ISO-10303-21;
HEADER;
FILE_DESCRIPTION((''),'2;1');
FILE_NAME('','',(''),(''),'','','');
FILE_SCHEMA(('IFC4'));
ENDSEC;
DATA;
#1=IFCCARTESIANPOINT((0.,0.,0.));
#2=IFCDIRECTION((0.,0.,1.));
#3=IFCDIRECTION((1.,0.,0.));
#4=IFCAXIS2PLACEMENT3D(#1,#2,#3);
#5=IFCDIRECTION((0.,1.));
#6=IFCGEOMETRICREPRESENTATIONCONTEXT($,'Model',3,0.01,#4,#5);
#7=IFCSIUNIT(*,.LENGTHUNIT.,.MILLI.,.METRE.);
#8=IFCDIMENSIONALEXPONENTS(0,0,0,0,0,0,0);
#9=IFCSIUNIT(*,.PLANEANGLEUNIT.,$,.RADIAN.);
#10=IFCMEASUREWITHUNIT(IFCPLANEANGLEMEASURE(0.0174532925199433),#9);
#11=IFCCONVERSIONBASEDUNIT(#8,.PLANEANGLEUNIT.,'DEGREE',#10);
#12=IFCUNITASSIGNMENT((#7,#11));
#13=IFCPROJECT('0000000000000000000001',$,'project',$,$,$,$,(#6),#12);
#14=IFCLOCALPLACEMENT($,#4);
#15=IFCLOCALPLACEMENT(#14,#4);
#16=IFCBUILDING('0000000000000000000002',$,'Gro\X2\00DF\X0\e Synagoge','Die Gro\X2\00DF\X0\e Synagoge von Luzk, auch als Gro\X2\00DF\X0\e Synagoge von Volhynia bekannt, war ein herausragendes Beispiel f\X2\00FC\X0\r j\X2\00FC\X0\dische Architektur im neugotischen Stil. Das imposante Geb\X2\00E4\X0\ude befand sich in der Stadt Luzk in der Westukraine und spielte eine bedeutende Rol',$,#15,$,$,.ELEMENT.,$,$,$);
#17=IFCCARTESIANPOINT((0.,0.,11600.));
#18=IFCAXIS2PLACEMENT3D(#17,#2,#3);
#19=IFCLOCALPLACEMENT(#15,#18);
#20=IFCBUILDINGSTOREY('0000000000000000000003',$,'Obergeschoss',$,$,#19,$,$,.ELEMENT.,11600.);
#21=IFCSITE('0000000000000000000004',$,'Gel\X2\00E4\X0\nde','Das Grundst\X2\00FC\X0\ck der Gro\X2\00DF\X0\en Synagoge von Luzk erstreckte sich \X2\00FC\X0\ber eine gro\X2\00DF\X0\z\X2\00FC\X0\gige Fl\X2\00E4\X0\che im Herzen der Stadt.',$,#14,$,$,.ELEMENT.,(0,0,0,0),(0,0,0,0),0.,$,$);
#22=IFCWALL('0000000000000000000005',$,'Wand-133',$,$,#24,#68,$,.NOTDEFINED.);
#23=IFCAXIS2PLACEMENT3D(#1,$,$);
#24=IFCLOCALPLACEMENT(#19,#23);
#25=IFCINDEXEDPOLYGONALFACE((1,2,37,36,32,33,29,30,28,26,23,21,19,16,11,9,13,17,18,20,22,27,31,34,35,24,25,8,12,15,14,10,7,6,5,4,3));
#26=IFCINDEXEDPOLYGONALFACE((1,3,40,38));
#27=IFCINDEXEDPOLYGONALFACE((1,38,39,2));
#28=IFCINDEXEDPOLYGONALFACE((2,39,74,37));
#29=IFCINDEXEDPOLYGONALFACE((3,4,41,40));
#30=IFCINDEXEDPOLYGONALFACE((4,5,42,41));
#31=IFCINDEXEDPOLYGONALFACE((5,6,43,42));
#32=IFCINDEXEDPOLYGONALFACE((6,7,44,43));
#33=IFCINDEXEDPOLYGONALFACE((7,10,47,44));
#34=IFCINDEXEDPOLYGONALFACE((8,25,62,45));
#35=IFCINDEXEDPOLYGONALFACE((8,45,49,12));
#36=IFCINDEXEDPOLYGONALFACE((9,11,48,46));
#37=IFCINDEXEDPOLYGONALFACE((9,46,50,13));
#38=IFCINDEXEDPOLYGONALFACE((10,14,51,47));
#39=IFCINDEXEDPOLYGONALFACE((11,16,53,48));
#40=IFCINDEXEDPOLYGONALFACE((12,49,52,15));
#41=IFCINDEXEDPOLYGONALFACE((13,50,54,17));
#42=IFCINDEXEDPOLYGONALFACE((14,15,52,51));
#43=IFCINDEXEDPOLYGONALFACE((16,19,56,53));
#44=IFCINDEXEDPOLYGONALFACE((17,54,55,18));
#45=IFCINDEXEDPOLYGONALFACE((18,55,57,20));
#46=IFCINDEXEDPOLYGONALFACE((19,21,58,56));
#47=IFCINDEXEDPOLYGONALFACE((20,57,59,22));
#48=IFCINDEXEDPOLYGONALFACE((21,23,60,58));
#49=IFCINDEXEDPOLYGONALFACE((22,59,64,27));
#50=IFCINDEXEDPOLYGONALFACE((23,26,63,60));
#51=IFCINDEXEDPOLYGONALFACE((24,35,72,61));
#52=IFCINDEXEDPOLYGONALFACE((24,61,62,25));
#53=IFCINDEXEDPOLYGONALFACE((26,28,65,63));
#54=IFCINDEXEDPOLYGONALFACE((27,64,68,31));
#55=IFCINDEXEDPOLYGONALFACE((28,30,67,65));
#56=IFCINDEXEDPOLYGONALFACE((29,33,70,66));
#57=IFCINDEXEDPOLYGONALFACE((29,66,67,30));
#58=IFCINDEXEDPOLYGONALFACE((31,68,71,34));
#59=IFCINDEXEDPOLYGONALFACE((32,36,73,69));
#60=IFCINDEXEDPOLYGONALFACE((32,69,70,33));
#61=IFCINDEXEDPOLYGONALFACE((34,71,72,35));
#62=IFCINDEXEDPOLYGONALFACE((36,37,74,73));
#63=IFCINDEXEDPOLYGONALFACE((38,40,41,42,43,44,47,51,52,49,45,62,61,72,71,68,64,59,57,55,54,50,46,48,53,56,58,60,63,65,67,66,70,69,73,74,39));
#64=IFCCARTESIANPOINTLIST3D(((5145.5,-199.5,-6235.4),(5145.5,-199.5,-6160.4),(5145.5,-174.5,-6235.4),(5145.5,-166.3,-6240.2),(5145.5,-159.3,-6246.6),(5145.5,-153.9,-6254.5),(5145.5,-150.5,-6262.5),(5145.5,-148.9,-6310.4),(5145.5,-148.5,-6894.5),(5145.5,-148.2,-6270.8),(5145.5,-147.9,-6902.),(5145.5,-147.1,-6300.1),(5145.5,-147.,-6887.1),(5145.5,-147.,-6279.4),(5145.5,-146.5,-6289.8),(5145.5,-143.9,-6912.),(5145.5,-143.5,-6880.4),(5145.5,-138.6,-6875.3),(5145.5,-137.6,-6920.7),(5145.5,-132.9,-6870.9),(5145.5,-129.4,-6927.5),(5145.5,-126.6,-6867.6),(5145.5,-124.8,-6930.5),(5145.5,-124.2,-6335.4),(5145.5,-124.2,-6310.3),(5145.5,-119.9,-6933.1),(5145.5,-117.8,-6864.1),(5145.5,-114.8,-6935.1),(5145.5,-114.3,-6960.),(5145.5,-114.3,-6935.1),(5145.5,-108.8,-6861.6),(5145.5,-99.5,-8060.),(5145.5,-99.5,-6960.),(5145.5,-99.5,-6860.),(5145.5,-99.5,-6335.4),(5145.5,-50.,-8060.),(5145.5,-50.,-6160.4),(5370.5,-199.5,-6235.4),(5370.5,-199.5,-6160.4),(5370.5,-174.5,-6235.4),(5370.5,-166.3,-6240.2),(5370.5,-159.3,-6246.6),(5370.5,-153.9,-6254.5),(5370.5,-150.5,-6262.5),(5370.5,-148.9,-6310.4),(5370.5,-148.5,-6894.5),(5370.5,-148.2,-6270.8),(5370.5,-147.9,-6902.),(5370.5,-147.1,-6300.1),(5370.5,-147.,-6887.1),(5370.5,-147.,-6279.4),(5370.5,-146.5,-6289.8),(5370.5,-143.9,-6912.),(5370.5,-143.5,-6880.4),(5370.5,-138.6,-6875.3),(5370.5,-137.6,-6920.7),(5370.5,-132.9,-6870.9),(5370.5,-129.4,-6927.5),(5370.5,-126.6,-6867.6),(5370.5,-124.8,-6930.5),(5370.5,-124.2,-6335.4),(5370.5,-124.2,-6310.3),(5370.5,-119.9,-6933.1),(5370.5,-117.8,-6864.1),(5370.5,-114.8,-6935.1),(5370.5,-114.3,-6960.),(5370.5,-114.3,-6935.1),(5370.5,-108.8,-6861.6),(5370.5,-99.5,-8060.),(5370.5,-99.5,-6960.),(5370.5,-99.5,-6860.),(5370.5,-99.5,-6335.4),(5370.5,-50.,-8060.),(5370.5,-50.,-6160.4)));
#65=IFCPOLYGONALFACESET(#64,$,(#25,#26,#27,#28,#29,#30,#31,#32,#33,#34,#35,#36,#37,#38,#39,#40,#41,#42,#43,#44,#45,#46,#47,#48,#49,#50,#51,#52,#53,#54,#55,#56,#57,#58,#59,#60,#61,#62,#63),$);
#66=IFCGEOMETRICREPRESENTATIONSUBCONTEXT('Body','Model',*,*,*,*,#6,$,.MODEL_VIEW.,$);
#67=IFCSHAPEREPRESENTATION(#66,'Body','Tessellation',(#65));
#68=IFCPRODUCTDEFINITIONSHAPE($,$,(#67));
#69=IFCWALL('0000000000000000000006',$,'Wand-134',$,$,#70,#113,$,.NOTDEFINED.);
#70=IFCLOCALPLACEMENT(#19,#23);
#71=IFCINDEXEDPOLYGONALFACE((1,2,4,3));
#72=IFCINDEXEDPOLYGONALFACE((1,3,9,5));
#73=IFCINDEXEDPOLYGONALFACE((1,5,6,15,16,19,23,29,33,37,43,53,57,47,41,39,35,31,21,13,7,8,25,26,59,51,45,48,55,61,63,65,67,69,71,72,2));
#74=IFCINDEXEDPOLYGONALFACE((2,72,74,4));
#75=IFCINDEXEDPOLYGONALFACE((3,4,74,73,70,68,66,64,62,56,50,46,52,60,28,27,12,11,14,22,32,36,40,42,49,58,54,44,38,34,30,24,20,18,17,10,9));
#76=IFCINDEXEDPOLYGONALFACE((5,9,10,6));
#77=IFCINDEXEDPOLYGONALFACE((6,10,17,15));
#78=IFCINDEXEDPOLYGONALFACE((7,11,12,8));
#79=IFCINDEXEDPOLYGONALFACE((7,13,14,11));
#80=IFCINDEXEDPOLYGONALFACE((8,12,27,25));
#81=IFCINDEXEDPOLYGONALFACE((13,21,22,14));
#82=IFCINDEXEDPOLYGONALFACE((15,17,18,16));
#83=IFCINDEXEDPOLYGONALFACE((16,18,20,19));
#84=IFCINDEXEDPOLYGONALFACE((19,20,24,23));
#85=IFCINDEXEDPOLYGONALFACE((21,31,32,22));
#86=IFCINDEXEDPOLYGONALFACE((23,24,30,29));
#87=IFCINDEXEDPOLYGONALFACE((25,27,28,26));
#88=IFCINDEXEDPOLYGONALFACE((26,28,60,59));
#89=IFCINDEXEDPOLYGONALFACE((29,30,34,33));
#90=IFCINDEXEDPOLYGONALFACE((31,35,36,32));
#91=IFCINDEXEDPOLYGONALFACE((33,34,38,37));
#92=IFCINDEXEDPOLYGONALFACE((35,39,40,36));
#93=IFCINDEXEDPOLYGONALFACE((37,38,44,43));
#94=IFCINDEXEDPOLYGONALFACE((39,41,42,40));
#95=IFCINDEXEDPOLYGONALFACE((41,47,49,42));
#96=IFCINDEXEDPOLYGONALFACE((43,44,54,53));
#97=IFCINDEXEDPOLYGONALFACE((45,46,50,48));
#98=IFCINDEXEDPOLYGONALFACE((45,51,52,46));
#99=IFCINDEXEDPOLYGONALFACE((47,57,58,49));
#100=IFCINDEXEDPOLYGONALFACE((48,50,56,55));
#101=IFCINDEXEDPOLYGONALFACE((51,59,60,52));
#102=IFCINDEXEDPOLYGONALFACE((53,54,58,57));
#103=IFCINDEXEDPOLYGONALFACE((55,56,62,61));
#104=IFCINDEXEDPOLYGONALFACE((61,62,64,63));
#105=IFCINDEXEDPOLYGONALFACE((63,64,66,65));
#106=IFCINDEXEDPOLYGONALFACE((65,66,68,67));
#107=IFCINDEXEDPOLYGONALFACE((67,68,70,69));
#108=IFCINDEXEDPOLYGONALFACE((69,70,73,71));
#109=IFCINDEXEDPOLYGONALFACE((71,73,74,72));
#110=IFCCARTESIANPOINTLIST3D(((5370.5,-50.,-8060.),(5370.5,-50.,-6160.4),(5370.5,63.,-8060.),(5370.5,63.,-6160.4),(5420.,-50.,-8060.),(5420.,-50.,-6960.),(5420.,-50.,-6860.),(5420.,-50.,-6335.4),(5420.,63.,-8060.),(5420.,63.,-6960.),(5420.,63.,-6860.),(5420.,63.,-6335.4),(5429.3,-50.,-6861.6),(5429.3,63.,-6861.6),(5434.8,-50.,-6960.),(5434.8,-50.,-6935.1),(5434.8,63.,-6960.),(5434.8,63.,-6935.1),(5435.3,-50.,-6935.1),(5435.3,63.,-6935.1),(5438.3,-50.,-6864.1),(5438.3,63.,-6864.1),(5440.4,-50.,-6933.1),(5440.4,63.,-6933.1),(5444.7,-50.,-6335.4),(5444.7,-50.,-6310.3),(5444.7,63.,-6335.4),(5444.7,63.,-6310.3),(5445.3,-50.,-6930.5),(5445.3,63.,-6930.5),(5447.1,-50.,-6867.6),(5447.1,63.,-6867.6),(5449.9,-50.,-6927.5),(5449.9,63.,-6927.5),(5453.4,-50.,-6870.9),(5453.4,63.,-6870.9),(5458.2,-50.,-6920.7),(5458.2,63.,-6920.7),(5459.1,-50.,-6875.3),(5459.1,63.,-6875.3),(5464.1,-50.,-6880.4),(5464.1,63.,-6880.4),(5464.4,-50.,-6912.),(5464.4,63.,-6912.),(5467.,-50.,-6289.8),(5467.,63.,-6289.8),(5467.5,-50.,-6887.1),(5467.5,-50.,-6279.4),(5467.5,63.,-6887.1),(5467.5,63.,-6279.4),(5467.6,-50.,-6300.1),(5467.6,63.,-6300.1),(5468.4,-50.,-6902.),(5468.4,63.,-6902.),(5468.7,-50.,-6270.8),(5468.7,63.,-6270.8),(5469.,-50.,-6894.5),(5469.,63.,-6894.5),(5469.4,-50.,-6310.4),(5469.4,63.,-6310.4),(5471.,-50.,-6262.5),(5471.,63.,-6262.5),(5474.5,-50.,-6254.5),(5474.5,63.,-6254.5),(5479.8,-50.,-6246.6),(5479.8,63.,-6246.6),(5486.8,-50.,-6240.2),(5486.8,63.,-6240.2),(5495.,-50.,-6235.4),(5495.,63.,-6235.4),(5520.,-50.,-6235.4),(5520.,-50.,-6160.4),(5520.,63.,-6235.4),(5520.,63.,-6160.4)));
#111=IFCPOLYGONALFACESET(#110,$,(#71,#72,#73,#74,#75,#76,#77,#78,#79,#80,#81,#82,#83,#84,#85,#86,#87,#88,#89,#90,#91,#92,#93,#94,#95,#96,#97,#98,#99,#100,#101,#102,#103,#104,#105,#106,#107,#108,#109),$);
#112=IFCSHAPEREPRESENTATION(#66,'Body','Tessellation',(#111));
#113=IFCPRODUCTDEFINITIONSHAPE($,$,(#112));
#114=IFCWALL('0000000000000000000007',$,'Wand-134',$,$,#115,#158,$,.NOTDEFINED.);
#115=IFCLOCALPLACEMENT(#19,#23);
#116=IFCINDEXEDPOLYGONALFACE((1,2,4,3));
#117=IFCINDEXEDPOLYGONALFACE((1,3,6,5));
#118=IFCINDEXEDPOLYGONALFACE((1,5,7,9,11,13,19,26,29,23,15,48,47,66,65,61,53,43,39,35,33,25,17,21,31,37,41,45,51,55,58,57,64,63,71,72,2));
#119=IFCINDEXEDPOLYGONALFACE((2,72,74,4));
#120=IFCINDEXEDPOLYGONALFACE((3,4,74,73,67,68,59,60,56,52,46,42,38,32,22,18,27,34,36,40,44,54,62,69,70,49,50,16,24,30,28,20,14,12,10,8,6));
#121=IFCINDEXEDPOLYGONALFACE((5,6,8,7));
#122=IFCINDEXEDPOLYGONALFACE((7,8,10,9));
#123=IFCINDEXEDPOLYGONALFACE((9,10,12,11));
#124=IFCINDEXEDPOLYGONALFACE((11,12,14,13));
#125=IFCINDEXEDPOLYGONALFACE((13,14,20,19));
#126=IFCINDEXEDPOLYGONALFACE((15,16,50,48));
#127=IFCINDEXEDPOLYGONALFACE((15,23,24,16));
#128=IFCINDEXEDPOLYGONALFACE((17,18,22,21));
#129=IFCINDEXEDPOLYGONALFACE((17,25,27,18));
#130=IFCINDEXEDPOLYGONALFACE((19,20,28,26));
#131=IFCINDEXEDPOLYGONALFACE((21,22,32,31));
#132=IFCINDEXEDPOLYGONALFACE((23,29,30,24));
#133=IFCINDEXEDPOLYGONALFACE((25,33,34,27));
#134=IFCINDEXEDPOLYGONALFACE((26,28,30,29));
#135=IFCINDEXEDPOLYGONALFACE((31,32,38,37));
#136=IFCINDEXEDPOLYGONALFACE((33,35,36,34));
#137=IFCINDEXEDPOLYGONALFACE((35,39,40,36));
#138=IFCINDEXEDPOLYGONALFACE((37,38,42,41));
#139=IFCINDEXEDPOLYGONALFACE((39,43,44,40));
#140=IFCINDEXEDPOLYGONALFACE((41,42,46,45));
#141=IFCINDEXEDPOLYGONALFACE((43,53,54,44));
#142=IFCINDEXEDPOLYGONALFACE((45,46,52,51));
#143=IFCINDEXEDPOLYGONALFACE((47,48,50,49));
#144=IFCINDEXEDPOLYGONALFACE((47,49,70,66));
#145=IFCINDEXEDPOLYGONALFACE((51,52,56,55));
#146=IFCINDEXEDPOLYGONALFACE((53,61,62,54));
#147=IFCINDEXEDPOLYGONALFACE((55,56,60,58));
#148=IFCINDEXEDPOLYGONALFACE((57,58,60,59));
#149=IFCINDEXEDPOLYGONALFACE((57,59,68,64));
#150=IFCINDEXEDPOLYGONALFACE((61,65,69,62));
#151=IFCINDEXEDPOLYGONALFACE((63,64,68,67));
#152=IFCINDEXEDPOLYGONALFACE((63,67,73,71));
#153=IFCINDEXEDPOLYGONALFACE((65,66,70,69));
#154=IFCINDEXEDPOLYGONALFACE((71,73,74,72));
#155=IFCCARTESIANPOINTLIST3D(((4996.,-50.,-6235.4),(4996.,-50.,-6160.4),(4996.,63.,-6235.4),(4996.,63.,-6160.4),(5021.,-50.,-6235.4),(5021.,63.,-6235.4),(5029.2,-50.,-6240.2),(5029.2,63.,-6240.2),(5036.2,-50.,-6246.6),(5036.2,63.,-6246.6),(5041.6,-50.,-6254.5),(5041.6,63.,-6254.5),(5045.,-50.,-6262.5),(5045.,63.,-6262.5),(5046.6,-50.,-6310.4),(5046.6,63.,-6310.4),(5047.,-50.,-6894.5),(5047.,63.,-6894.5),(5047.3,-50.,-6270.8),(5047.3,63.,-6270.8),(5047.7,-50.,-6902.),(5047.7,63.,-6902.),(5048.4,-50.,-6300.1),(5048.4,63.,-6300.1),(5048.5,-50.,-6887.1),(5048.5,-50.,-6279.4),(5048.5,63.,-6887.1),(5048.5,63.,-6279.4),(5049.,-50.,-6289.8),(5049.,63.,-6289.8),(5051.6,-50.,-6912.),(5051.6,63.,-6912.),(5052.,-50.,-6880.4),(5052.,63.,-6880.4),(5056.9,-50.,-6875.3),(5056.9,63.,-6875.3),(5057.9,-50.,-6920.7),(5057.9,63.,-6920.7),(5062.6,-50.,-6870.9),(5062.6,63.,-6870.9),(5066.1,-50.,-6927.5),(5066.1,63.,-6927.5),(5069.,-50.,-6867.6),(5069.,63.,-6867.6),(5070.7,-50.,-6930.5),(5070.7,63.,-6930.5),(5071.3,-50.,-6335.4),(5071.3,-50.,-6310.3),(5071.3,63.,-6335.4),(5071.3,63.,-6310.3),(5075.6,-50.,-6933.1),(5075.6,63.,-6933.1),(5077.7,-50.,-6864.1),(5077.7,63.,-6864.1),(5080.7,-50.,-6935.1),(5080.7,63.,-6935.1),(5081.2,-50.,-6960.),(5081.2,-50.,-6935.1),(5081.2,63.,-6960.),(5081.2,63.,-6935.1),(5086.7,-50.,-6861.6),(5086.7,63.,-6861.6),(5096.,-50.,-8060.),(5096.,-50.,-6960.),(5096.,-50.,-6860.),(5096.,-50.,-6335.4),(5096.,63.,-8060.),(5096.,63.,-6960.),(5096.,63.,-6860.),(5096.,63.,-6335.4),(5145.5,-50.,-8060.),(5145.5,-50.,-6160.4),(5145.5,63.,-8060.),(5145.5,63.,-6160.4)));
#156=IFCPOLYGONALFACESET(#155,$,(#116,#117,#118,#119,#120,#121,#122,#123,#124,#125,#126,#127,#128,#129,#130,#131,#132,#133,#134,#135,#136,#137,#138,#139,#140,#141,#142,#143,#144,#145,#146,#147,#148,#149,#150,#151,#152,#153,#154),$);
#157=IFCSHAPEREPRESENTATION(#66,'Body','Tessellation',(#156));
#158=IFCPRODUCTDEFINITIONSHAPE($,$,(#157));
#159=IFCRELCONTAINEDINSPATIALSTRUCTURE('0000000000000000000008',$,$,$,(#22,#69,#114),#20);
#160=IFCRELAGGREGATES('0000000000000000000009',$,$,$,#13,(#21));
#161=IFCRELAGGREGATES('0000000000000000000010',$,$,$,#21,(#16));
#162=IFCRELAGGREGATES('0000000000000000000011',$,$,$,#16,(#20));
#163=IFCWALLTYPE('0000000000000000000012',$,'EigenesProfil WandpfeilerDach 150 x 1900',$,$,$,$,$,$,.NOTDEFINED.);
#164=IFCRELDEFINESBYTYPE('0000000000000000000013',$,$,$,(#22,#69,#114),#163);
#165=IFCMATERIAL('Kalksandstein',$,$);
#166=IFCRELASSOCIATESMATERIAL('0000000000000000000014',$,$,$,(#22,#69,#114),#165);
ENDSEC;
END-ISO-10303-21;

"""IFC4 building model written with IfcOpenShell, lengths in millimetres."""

from ifc_helpers import new_model, entity, si_unit, converted_unit, direction, frame, origin_with_axes, place, context, subcontext, project, spatial, line, arc, indexed_curve, outline, extrude, material, material_profile, profile_set, type_object, element, save


model = new_model("IFC4")

# Units and contexts
model_context = context("Model", 3, precision=0.01, world=origin_with_axes(), true_north=direction((0.0, 1.0)))
body_context = subcontext(model_context, "Body", "Model", "MODEL_VIEW")
ifc_project = project(units=[si_unit("LENGTHUNIT", "METRE", prefix="MILLI"), converted_unit("PLANEANGLEUNIT", "DEGREE", entity("IfcPlaneAngleMeasure", 0.0174532925199433), si_unit("PLANEANGLEUNIT", "RADIAN"), dimensions=[0, 0, 0, 0, 0, 0, 0])], contexts=[model_context])

# Site, building, storey
site_placement = place(None, origin_with_axes())
site = spatial("IfcSite", under=ifc_project, at=site_placement, Name="Gelände", Description="Das Grundstück der Großen Synagoge von Luzk erstreckte sich über eine großzügige Fläche im Herzen der Stadt.", CompositionType="ELEMENT", RefLatitude=(0, 0, 0, 0), RefLongitude=(0, 0, 0, 0), RefElevation=0.0)
building_placement = place(site_placement, origin_with_axes())
building = spatial("IfcBuilding", under=site, at=building_placement, Name="Große Synagoge", Description="Die Große Synagoge von Luzk, auch als Große Synagoge von Volhynia bekannt, war ein herausragendes Beispiel für jüdische Architektur im neugotischen Stil. Das imposante Gebäude befand sich in der Stadt Luzk in der Westukraine und spielte eine bedeutende Rol", CompositionType="ELEMENT")
storey_placement = place(building_placement, frame((0.0, 0.0, 11600.0), z_axis=(0.0, 0.0, 1.0), x_axis=(1.0, 0.0, 0.0)))
storey = spatial("IfcBuildingStorey", under=building, at=storey_placement, Name="Obergeschoss", CompositionType="ELEMENT", Elevation=11600.0)

# Walls
ifc_material_1 = material(Name="Kalksandstein")
ifc_material_profile = material_profile(ifc_material_1, outline(indexed_curve([(74.2, 1749.6), (98.9, 1749.6), (96.7, 1765.0), (97.0, 1780.5), (99.2, 1793.4), (103.9, 1805.5), (112.6, 1816.7), (124.5, 1824.6), (149.5, 1824.6), (149.5, 1899.6), (0.0, 1899.6), (0.0, 0.0), (49.5, 0.0), (49.5, 1100.0), (64.3, 1100.0), (64.3, 1124.9), (64.8, 1124.9), (72.4, 1128.1), (79.4, 1132.4), (91.1, 1143.4), (97.9, 1157.9), (98.0, 1169.2), (93.5, 1179.5), (85.8, 1187.0), (76.6, 1192.3), (63.3, 1197.2), (49.5, 1200.0), (49.5, 1724.6), (74.2, 1724.6)], segments=[line(1, 2), arc(2, 3, 4), arc(4, 5, 6), arc(6, 7, 8), line(8, 9, 10, 11, 12, 13, 14, 15, 16, 17), arc(17, 18, 19), arc(19, 20, 21), arc(21, 22, 23), arc(23, 24, 25), arc(25, 26, 27), line(27, 28, 29, 1)])), Name="Kalksandstein")
ifc_profile_set = profile_set([ifc_material_profile], Name="EigenesProfil WandpfeilerDach")
wall_type_1 = type_object("IfcWallType", Name="EigenesProfil WandpfeilerDach 150 x 1900", PredefinedType="NOTDEFINED")
wall_1_placement = place(storey_placement, frame((5145.5, -50.0, -8060.0), z_axis=(0.0, 0.0, 1.0), x_axis=(1.0, 0.0, 0.0)))
element("IfcWall", 1, at=wall_1_placement, inside=storey, type_object=wall_type_1, material=ifc_profile_set, Name="Wand-133", PredefinedType="NOTDEFINED", context=body_context, shape_type="SweptSolid", body=[
    extrude(outline(indexed_curve([(74.2, 1749.6), (98.9, 1749.6), (96.7, 1765.0), (97.0, 1780.5), (99.2, 1793.4), (103.9, 1805.5), (112.6, 1816.7), (124.5, 1824.6), (149.5, 1824.6), (149.5, 1899.6), (0.0, 1899.6), (0.0, 0.0), (49.5, 0.0), (49.5, 1100.0), (64.3, 1100.0), (64.3, 1124.9), (64.8, 1124.9), (72.4, 1128.1), (79.4, 1132.4), (91.1, 1143.4), (97.9, 1157.9), (98.0, 1169.2), (93.5, 1179.5), (85.8, 1187.0), (76.6, 1192.3), (63.3, 1197.2), (49.5, 1200.0), (49.5, 1724.6), (74.2, 1724.6)], segments=[line(1, 2), arc(2, 3, 4), arc(4, 5, 6), arc(6, 7, 8), line(8, 9, 10, 11, 12, 13, 14, 15, 16, 17), arc(17, 18, 19), arc(19, 20, 21), arc(21, 22, 23), arc(23, 24, 25), arc(25, 26, 27), line(27, 28, 29, 1)])), frame((0.0, 0.0, 0.0), z_axis=(-1.0, 0.0, 0.0), x_axis=(0.0, -1.0, 0.0)), (0.0, 0.0, -1.0), 225.0),
])
wall_2_placement = place(storey_placement, frame((5370.5, -50.0, -8060.0), z_axis=(0.0, 0.0, 1.0), x_axis=(0.0, 1.0, 0.0)))
element("IfcWall", 2, at=wall_2_placement, inside=storey, type_object=wall_type_1, material=ifc_profile_set, Name="Wand-134", PredefinedType="NOTDEFINED", context=body_context, shape_type="SweptSolid", body=[
    extrude(outline(indexed_curve([(74.2, 1749.6), (98.9, 1749.6), (96.7, 1765.0), (97.0, 1780.5), (99.2, 1793.4), (103.9, 1805.5), (112.6, 1816.7), (124.5, 1824.6), (149.5, 1824.6), (149.5, 1899.6), (0.0, 1899.6), (0.0, 0.0), (49.5, 0.0), (49.5, 1100.0), (64.3, 1100.0), (64.3, 1124.9), (64.8, 1124.9), (72.4, 1128.1), (79.4, 1132.4), (91.1, 1143.4), (97.9, 1157.9), (98.0, 1169.2), (93.5, 1179.5), (85.8, 1187.0), (76.6, 1192.3), (63.3, 1197.2), (49.5, 1200.0), (49.5, 1724.6), (74.2, 1724.6)], segments=[line(1, 2), arc(2, 3, 4), arc(4, 5, 6), arc(6, 7, 8), line(8, 9, 10, 11, 12, 13, 14, 15, 16, 17), arc(17, 18, 19), arc(19, 20, 21), arc(21, 22, 23), arc(23, 24, 25), arc(25, 26, 27), line(27, 28, 29, 1)])), frame((0.0, 0.0, 0.0), z_axis=(-1.0, 0.0, 0.0), x_axis=(0.0, -1.0, 0.0)), (0.0, 0.0, -1.0), 113.0),
])
wall_3_placement = place(storey_placement, frame((5145.5, -50.0, -8060.0), z_axis=(0.0, 0.0, 1.0), x_axis=(0.0, 1.0, 0.0)))
element("IfcWall", 3, at=wall_3_placement, inside=storey, type_object=wall_type_1, material=ifc_profile_set, Name="Wand-134", PredefinedType="NOTDEFINED", context=body_context, shape_type="SweptSolid", body=[
    extrude(outline(indexed_curve([(74.2, 1749.6), (98.9, 1749.6), (96.7, 1765.0), (97.0, 1780.5), (99.2, 1793.4), (103.9, 1805.5), (112.6, 1816.7), (124.5, 1824.6), (149.5, 1824.6), (149.5, 1899.6), (0.0, 1899.6), (0.0, 0.0), (49.5, 0.0), (49.5, 1100.0), (64.3, 1100.0), (64.3, 1124.9), (64.8, 1124.9), (72.4, 1128.1), (79.4, 1132.4), (91.1, 1143.4), (97.9, 1157.9), (98.0, 1169.2), (93.5, 1179.5), (85.8, 1187.0), (76.6, 1192.3), (63.3, 1197.2), (49.5, 1200.0), (49.5, 1724.6), (74.2, 1724.6)], segments=[line(1, 2), arc(2, 3, 4), arc(4, 5, 6), arc(6, 7, 8), line(8, 9, 10, 11, 12, 13, 14, 15, 16, 17), arc(17, 18, 19), arc(19, 20, 21), arc(21, 22, 23), arc(23, 24, 25), arc(25, 26, 27), line(27, 28, 29, 1)])), frame((0.0, 0.0, 0.0), z_axis=(1.0, 0.0, 0.0), x_axis=(0.0, 1.0, 0.0)), (0.0, 0.0, 1.0), 113.0),
])

save(model, "model.ifc")
